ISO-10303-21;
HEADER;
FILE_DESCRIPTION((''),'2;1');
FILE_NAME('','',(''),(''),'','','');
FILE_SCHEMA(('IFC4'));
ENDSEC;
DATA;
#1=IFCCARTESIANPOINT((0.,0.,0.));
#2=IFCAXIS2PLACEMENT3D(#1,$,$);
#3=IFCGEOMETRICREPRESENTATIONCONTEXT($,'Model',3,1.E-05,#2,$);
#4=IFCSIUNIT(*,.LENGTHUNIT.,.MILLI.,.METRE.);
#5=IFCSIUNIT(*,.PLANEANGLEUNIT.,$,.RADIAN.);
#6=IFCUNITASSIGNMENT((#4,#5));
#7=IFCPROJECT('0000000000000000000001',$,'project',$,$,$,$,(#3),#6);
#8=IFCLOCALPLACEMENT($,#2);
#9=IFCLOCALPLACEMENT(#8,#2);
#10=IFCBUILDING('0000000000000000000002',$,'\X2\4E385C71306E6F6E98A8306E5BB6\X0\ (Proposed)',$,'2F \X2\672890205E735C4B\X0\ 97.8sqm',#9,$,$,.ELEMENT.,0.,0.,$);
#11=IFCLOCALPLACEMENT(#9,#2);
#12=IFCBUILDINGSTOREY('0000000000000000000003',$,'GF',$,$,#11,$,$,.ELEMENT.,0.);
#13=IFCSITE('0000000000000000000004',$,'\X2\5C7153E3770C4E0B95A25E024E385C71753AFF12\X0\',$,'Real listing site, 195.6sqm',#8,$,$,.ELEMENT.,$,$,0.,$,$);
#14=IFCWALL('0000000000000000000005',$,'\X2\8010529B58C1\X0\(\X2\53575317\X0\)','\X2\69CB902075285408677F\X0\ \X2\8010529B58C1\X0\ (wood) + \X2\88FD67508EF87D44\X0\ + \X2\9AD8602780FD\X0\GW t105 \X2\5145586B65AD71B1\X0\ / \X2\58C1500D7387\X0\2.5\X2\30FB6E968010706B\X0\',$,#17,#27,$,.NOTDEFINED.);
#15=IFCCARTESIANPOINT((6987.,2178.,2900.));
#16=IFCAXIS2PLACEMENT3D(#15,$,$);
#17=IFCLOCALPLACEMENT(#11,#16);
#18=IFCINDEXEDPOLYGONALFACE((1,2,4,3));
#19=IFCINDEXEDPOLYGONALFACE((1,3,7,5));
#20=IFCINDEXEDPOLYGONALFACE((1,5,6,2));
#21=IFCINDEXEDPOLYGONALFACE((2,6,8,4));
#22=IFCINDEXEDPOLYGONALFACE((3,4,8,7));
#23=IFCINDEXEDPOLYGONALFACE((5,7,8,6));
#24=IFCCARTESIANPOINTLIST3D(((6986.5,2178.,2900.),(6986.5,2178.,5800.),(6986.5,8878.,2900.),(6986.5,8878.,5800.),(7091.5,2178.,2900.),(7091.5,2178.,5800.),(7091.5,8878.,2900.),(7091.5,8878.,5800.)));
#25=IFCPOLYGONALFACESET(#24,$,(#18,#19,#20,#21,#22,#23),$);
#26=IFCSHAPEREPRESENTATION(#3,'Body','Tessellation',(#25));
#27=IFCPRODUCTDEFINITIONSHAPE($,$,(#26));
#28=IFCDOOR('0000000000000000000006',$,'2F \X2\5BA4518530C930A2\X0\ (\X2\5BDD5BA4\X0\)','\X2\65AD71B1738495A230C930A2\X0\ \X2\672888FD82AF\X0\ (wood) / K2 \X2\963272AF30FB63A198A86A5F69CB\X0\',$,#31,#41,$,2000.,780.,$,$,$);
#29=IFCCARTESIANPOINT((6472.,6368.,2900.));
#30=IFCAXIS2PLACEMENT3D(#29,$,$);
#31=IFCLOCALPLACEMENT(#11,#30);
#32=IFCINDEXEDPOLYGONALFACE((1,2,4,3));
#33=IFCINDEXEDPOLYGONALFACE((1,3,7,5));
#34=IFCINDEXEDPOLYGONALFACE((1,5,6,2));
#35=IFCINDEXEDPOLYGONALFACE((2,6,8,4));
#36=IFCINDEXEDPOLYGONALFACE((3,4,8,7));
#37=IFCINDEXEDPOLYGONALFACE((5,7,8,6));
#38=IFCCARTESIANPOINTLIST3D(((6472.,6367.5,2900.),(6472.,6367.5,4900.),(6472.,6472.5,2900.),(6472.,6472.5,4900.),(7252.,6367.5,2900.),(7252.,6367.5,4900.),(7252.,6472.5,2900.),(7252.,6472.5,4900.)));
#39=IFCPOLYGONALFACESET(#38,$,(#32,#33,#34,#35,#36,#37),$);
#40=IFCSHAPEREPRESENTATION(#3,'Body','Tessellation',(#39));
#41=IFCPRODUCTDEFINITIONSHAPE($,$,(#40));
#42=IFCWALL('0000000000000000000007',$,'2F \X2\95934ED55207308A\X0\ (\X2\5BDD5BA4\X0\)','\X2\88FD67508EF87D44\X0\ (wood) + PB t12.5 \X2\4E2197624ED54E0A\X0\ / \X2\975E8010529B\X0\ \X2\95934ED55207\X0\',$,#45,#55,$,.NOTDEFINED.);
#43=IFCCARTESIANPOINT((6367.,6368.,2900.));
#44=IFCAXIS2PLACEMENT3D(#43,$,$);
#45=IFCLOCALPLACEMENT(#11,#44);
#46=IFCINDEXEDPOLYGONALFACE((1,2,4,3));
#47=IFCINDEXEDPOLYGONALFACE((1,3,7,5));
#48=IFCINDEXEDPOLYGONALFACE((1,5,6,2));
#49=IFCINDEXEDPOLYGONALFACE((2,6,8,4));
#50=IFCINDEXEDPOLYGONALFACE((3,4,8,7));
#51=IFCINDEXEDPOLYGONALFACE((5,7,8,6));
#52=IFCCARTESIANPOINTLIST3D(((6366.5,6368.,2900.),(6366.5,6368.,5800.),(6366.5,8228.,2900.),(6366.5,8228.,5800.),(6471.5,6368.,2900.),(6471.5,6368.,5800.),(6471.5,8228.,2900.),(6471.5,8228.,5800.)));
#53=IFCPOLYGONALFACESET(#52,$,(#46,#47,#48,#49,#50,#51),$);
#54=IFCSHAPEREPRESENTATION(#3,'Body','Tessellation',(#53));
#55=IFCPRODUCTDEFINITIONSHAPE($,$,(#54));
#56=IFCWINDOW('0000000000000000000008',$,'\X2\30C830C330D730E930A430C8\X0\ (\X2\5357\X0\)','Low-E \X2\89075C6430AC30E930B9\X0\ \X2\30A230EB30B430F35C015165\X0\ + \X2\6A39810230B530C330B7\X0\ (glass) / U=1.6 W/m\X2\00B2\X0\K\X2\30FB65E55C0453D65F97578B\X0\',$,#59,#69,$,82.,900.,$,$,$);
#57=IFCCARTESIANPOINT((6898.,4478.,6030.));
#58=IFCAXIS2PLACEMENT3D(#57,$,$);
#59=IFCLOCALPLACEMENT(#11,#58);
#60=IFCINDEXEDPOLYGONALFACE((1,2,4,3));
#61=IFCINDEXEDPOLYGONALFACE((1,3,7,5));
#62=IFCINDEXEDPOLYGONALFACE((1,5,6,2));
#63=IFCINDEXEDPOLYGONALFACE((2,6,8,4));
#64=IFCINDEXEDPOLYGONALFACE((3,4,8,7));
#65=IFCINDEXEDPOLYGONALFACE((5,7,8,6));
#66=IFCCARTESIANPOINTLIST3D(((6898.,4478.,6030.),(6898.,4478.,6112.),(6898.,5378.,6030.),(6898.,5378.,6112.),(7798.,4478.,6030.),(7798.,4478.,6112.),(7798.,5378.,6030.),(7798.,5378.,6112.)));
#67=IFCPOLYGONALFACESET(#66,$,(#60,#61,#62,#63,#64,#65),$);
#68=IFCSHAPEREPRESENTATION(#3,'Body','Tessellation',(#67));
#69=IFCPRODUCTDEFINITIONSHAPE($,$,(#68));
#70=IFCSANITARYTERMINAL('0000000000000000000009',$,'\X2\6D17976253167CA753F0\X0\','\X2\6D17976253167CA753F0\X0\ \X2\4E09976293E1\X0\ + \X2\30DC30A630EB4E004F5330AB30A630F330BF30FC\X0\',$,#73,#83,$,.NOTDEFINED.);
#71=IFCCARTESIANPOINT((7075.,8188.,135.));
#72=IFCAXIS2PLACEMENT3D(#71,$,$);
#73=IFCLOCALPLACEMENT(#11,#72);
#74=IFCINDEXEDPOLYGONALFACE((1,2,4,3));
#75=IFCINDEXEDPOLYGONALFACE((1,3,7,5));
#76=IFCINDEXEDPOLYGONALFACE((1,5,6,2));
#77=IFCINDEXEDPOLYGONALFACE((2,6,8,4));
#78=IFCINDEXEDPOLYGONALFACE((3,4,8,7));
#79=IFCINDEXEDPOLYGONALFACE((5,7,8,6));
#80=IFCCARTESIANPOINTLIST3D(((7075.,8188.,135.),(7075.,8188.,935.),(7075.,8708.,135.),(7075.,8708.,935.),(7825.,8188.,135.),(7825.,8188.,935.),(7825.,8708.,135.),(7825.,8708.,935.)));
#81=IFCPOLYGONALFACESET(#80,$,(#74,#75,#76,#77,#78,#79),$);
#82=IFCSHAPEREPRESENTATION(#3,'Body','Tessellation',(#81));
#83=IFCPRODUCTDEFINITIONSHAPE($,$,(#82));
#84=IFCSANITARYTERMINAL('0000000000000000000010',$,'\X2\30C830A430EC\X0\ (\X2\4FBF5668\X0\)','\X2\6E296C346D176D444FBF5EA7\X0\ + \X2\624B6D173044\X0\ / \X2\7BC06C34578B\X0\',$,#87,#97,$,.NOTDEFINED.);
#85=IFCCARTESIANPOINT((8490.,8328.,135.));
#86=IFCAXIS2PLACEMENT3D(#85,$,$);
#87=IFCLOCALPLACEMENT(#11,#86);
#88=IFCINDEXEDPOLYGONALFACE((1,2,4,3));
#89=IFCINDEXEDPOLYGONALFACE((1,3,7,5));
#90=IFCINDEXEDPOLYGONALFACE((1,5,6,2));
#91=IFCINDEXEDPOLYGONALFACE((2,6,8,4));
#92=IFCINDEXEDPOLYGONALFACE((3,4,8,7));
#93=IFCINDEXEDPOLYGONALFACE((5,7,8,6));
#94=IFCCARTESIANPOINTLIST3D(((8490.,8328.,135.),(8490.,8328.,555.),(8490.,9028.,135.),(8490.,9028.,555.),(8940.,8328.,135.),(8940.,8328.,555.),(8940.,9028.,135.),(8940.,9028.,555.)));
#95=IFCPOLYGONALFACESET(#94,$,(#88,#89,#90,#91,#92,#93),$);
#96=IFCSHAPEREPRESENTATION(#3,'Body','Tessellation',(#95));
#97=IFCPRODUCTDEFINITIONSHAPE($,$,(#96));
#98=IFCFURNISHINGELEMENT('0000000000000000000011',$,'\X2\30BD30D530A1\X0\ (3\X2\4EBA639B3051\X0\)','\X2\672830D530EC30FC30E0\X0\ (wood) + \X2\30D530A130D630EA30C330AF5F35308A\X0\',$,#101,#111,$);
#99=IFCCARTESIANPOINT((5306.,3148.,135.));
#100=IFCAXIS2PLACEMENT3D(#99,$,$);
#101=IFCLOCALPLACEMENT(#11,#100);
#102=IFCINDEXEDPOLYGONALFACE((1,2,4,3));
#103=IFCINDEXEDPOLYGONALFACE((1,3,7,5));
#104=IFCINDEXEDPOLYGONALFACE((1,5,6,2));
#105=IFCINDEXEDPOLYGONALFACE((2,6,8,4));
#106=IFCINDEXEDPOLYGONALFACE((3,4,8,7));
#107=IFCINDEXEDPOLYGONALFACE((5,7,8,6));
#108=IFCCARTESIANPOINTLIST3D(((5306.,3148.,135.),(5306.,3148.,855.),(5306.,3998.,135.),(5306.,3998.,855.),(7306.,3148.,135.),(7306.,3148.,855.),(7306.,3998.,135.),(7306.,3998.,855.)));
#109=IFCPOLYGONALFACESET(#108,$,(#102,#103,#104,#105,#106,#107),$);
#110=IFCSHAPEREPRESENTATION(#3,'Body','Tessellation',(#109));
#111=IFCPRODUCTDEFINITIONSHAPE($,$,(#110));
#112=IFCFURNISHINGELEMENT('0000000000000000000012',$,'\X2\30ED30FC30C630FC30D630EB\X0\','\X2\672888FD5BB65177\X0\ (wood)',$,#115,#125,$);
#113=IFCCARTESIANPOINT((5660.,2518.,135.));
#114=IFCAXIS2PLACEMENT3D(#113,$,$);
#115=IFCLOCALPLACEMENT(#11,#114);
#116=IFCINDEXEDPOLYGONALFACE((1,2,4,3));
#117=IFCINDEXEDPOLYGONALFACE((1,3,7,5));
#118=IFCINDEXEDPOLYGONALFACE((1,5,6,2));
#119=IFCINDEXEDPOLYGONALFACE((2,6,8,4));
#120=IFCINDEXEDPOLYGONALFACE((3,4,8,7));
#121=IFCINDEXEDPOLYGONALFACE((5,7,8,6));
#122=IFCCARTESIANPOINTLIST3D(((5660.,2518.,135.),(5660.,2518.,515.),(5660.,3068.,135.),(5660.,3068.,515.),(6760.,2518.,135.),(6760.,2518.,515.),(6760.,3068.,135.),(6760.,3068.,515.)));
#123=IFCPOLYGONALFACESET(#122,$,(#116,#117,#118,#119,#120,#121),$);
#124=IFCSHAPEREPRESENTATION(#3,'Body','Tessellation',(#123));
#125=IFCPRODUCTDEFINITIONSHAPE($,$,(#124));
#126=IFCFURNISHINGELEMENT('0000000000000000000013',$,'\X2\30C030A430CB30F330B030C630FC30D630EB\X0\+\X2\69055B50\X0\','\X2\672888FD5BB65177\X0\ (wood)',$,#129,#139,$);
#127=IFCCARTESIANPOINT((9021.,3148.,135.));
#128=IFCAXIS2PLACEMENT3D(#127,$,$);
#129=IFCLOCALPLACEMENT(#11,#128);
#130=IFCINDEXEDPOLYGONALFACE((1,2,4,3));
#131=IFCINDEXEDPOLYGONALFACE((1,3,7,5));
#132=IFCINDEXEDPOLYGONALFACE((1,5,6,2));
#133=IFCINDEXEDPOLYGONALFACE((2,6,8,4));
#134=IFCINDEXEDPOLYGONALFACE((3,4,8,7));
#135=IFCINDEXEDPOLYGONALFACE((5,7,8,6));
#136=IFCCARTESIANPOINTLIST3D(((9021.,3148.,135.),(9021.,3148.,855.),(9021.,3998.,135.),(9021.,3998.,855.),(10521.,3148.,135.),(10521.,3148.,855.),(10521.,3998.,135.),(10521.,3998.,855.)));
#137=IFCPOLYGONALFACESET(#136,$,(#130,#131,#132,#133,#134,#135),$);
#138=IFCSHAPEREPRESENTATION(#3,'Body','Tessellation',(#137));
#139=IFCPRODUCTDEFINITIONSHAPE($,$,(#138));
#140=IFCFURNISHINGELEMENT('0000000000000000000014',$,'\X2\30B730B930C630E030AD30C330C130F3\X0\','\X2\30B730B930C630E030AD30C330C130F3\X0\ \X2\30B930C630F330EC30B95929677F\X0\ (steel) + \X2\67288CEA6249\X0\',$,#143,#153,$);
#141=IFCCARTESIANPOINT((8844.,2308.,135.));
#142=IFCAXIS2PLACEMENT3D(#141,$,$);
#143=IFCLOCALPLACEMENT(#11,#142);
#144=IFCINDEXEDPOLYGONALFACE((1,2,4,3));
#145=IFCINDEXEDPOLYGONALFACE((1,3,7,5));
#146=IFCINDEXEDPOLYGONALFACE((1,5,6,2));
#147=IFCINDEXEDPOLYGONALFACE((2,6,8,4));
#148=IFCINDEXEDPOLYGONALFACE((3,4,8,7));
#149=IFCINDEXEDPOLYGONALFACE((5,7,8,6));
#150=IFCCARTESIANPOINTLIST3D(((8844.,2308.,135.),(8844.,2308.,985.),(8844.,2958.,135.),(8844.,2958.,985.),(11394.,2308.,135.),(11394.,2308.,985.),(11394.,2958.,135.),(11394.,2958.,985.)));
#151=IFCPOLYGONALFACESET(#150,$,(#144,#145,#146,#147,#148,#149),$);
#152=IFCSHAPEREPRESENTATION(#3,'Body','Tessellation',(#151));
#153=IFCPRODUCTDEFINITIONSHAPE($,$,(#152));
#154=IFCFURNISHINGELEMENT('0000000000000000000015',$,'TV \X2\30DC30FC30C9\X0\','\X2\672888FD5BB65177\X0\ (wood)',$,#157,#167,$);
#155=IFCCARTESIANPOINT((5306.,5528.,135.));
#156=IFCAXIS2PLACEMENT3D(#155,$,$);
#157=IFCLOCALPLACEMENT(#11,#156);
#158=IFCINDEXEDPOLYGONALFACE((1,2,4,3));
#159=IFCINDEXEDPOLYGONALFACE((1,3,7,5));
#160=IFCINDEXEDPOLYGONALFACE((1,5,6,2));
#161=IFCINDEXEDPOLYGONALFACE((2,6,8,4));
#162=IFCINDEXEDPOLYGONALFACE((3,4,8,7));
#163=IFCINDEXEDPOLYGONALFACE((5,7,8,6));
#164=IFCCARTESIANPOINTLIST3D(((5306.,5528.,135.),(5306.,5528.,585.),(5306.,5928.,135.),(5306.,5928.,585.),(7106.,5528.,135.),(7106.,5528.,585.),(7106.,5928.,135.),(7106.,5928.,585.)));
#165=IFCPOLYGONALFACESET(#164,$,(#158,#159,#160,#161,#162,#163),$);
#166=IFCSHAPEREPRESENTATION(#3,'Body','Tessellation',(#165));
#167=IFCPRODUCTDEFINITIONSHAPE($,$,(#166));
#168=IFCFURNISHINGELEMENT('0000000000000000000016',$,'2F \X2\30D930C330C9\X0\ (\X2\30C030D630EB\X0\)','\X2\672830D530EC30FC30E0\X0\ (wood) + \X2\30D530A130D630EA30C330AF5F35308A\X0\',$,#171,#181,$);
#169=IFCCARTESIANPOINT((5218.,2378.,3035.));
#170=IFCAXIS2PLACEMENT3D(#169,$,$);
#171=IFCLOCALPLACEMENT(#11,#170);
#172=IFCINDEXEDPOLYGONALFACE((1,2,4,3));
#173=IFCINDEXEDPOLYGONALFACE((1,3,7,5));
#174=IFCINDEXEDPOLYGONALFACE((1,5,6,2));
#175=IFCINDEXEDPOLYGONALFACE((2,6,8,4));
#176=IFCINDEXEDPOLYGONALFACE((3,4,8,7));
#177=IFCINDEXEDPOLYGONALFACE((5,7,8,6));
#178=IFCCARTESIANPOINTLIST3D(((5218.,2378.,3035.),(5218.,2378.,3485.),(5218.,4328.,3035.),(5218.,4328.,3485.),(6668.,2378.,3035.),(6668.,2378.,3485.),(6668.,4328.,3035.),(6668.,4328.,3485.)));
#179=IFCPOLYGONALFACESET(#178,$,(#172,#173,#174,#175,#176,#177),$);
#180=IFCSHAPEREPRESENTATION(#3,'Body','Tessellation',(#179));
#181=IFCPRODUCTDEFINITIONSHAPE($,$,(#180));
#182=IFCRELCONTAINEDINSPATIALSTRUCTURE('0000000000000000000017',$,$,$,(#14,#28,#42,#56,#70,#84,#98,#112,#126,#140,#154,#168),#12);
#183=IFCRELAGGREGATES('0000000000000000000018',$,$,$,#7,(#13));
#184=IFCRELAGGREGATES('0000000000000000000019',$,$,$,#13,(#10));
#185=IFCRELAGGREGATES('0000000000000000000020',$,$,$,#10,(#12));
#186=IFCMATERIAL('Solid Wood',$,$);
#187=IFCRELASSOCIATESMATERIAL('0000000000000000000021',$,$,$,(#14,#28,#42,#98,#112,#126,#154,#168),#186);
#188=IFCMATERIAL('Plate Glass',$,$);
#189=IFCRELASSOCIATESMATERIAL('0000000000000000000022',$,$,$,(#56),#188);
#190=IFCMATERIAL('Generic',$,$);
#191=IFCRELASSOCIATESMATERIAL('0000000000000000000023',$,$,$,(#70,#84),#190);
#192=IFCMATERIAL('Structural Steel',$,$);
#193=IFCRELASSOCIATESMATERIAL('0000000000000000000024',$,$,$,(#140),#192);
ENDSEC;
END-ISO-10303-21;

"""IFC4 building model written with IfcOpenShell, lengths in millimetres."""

from ifc_helpers import new_model, si_unit, frame, frame_2d, origin, place, context, project, spatial, rectangle, extrude, material, element, fill, save


model = new_model("IFC4")

# Units and contexts
model_context = context("Model", 3, precision=1e-05, world=origin())
ifc_project = project(units=[si_unit("LENGTHUNIT", "METRE", prefix="MILLI"), si_unit("PLANEANGLEUNIT", "RADIAN")], contexts=[model_context])

# Site, building, storey
site_placement = place(None, origin())
site = spatial("IfcSite", under=ifc_project, at=site_placement, Name="山口県下関市丸山町２", ObjectType="Real listing site, 195.6sqm", CompositionType="ELEMENT", RefElevation=0.0)
building_placement = place(site_placement, origin())
building = spatial("IfcBuilding", under=site, at=building_placement, Name="丸山の潮風の家 (Proposed)", ObjectType="2F 木造平屋 97.8sqm", CompositionType="ELEMENT", ElevationOfRefHeight=0.0, ElevationOfTerrain=0.0)
storey_placement = place(building_placement, origin())
storey = spatial("IfcBuildingStorey", under=building, at=storey_placement, Name="GF", CompositionType="ELEMENT", Elevation=0.0)

# Shared definitions
ifc_material_1 = material(Name="Solid Wood")

# Wall, opening, door
wall_1_placement = place(storey_placement, frame((6987.0, 2178.0, 2900.0)))
wall_1 = element("IfcWall", 1, at=wall_1_placement, inside=storey, material=ifc_material_1, Name="耐力壁(南北)", Description="構造用合板 耐力壁 (wood) + 製材軸組 + 高性能GW t105 充填断熱 / 壁倍率2.5・準耐火", PredefinedType="NOTDEFINED", context=model_context, shape_type="SweptSolid", body=[
    extrude(rectangle(XDim=105.0, YDim=6700.0, at=frame_2d((52.0, 3350.0))), frame((6987.0, 2178.0, 2900.0)), (0.0, 0.0, 1.0), 2900.0),
])
opening_1_placement = place(storey_placement, frame((6472.0, 6368.0, 2900.0)))
opening_1 = element("IfcOpeningElement", 2, at=opening_1_placement, cuts=wall_1, PredefinedType="NOTDEFINED", context=model_context, shape_type="SweptSolid", body=[
    extrude(rectangle(XDim=780.0, YDim=105.0, at=frame_2d((390.0, 52.0))), frame((6472.0, 6368.0, 2900.0)), (0.0, 0.0, 1.0), 2000.0),
])
door_1_placement = place(storey_placement, frame((6472.0, 6368.0, 2900.0)))
door_1 = element("IfcDoor", 3, at=door_1_placement, inside=storey, material=ifc_material_1, Name="2F 室内ドア (寝室)", Description="断熱玄関ドア 木製芯 (wood) / K2 防犯・採風機構", OverallHeight=2000.0, OverallWidth=780.0, context=model_context, shape_type="SweptSolid", body=[
    extrude(rectangle(XDim=780.0, YDim=105.0, at=frame_2d((390.0, 52.0))), frame((6472.0, 6368.0, 2900.0)), (0.0, 0.0, 1.0), 2000.0),
])
fill(opening_1, door_1)

# Wall
wall_2_placement = place(storey_placement, frame((6367.0, 6368.0, 2900.0)))
element("IfcWall", 4, at=wall_2_placement, inside=storey, material=ifc_material_1, Name="2F 間仕切り (寝室)", Description="製材軸組 (wood) + PB t12.5 両面仕上 / 非耐力 間仕切", PredefinedType="NOTDEFINED", context=model_context, shape_type="SweptSolid", body=[
    extrude(rectangle(XDim=105.0, YDim=1860.0, at=frame_2d((52.0, 930.0))), frame((6367.0, 6368.0, 2900.0)), (0.0, 0.0, 1.0), 2900.0),
])

# Window
ifc_material_2 = material(Name="Plate Glass")
window_placement = place(storey_placement, frame((6898.0, 4478.0, 6030.0)))
element("IfcWindow", 5, at=window_placement, inside=storey, material=ifc_material_2, Name="トップライト (南)", Description="Low-E 複層ガラス アルゴン封入 + 樹脂サッシ (glass) / U=1.6 W/m²K・日射取得型", OverallHeight=82.0, OverallWidth=900.0, context=model_context, shape_type="SweptSolid", body=[
    extrude(rectangle(XDim=900.0, YDim=900.0, at=frame_2d((450.0, 450.0))), frame((6898.0, 4478.0, 6030.0)), (0.0, 0.0, 1.0), 82.0),
])

# Sanitary terminals
ifc_material_3 = material(Name="Generic")
sanitary_terminal_1_placement = place(storey_placement, frame((7075.0, 8188.0, 135.0)))
element("IfcSanitaryTerminal", 6, at=sanitary_terminal_1_placement, inside=storey, material=ifc_material_3, Name="洗面化粧台", Description="洗面化粧台 三面鏡 + ボウル一体カウンター", PredefinedType="NOTDEFINED", context=model_context, shape_type="SweptSolid", body=[
    extrude(rectangle(XDim=750.0, YDim=520.0, at=frame_2d((375.0, 260.0))), frame((7075.0, 8188.0, 135.0)), (0.0, 0.0, 1.0), 800.0),
])
sanitary_terminal_2_placement = place(storey_placement, frame((8490.0, 8328.0, 135.0)))
element("IfcSanitaryTerminal", 7, at=sanitary_terminal_2_placement, inside=storey, material=ifc_material_3, Name="トイレ (便器)", Description="温水洗浄便座 + 手洗い / 節水型", PredefinedType="NOTDEFINED", context=model_context, shape_type="SweptSolid", body=[
    extrude(rectangle(XDim=450.0, YDim=700.0, at=frame_2d((225.0, 350.0))), frame((8490.0, 8328.0, 135.0)), (0.0, 0.0, 1.0), 420.0),
])

# Furnishing elements
furnishing_1_placement = place(storey_placement, frame((5306.0, 3148.0, 135.0)))
element("IfcFurnishingElement", 8, at=furnishing_1_placement, inside=storey, material=ifc_material_1, Name="ソファ (3人掛け)", Description="木フレーム (wood) + ファブリック張り", context=model_context, shape_type="SweptSolid", body=[
    extrude(rectangle(XDim=2000.0, YDim=850.0, at=frame_2d((1000.0, 425.0))), frame((5306.0, 3148.0, 135.0)), (0.0, 0.0, 1.0), 720.0),
])
furnishing_2_placement = place(storey_placement, frame((5660.0, 2518.0, 135.0)))
element("IfcFurnishingElement", 9, at=furnishing_2_placement, inside=storey, material=ifc_material_1, Name="ローテーブル", Description="木製家具 (wood)", context=model_context, shape_type="SweptSolid", body=[
    extrude(rectangle(XDim=1100.0, YDim=550.0, at=frame_2d((550.0, 275.0))), frame((5660.0, 2518.0, 135.0)), (0.0, 0.0, 1.0), 380.0),
])
furnishing_3_placement = place(storey_placement, frame((9021.0, 3148.0, 135.0)))
element("IfcFurnishingElement", 10, at=furnishing_3_placement, inside=storey, material=ifc_material_1, Name="ダイニングテーブル+椅子", Description="木製家具 (wood)", context=model_context, shape_type="SweptSolid", body=[
    extrude(rectangle(XDim=1500.0, YDim=850.0, at=frame_2d((750.0, 425.0))), frame((9021.0, 3148.0, 135.0)), (0.0, 0.0, 1.0), 720.0),
])
ifc_material_4 = material(Name="Structural Steel")
furnishing_4_placement = place(storey_placement, frame((8844.0, 2308.0, 135.0)))
element("IfcFurnishingElement", 11, at=furnishing_4_placement, inside=storey, material=ifc_material_4, Name="システムキッチン", Description="システムキッチン ステンレス天板 (steel) + 木質扉", context=model_context, shape_type="SweptSolid", body=[
    extrude(rectangle(XDim=2550.0, YDim=650.0, at=frame_2d((1275.0, 325.0))), frame((8844.0, 2308.0, 135.0)), (0.0, 0.0, 1.0), 850.0),
])
furnishing_5_placement = place(storey_placement, frame((5306.0, 5528.0, 135.0)))
element("IfcFurnishingElement", 12, at=furnishing_5_placement, inside=storey, material=ifc_material_1, Name="TV ボード", Description="木製家具 (wood)", context=model_context, shape_type="SweptSolid", body=[
    extrude(rectangle(XDim=1800.0, YDim=400.0, at=frame_2d((900.0, 200.0))), frame((5306.0, 5528.0, 135.0)), (0.0, 0.0, 1.0), 450.0),
])
furnishing_6_placement = place(storey_placement, frame((5218.0, 2378.0, 3035.0)))
element("IfcFurnishingElement", 13, at=furnishing_6_placement, inside=storey, material=ifc_material_1, Name="2F ベッド (ダブル)", Description="木フレーム (wood) + ファブリック張り", context=model_context, shape_type="SweptSolid", body=[
    extrude(rectangle(XDim=1450.0, YDim=1950.0, at=frame_2d((725.0, 975.0))), frame((5218.0, 2378.0, 3035.0)), (0.0, 0.0, 1.0), 450.0),
])

save(model, "model.ifc")
